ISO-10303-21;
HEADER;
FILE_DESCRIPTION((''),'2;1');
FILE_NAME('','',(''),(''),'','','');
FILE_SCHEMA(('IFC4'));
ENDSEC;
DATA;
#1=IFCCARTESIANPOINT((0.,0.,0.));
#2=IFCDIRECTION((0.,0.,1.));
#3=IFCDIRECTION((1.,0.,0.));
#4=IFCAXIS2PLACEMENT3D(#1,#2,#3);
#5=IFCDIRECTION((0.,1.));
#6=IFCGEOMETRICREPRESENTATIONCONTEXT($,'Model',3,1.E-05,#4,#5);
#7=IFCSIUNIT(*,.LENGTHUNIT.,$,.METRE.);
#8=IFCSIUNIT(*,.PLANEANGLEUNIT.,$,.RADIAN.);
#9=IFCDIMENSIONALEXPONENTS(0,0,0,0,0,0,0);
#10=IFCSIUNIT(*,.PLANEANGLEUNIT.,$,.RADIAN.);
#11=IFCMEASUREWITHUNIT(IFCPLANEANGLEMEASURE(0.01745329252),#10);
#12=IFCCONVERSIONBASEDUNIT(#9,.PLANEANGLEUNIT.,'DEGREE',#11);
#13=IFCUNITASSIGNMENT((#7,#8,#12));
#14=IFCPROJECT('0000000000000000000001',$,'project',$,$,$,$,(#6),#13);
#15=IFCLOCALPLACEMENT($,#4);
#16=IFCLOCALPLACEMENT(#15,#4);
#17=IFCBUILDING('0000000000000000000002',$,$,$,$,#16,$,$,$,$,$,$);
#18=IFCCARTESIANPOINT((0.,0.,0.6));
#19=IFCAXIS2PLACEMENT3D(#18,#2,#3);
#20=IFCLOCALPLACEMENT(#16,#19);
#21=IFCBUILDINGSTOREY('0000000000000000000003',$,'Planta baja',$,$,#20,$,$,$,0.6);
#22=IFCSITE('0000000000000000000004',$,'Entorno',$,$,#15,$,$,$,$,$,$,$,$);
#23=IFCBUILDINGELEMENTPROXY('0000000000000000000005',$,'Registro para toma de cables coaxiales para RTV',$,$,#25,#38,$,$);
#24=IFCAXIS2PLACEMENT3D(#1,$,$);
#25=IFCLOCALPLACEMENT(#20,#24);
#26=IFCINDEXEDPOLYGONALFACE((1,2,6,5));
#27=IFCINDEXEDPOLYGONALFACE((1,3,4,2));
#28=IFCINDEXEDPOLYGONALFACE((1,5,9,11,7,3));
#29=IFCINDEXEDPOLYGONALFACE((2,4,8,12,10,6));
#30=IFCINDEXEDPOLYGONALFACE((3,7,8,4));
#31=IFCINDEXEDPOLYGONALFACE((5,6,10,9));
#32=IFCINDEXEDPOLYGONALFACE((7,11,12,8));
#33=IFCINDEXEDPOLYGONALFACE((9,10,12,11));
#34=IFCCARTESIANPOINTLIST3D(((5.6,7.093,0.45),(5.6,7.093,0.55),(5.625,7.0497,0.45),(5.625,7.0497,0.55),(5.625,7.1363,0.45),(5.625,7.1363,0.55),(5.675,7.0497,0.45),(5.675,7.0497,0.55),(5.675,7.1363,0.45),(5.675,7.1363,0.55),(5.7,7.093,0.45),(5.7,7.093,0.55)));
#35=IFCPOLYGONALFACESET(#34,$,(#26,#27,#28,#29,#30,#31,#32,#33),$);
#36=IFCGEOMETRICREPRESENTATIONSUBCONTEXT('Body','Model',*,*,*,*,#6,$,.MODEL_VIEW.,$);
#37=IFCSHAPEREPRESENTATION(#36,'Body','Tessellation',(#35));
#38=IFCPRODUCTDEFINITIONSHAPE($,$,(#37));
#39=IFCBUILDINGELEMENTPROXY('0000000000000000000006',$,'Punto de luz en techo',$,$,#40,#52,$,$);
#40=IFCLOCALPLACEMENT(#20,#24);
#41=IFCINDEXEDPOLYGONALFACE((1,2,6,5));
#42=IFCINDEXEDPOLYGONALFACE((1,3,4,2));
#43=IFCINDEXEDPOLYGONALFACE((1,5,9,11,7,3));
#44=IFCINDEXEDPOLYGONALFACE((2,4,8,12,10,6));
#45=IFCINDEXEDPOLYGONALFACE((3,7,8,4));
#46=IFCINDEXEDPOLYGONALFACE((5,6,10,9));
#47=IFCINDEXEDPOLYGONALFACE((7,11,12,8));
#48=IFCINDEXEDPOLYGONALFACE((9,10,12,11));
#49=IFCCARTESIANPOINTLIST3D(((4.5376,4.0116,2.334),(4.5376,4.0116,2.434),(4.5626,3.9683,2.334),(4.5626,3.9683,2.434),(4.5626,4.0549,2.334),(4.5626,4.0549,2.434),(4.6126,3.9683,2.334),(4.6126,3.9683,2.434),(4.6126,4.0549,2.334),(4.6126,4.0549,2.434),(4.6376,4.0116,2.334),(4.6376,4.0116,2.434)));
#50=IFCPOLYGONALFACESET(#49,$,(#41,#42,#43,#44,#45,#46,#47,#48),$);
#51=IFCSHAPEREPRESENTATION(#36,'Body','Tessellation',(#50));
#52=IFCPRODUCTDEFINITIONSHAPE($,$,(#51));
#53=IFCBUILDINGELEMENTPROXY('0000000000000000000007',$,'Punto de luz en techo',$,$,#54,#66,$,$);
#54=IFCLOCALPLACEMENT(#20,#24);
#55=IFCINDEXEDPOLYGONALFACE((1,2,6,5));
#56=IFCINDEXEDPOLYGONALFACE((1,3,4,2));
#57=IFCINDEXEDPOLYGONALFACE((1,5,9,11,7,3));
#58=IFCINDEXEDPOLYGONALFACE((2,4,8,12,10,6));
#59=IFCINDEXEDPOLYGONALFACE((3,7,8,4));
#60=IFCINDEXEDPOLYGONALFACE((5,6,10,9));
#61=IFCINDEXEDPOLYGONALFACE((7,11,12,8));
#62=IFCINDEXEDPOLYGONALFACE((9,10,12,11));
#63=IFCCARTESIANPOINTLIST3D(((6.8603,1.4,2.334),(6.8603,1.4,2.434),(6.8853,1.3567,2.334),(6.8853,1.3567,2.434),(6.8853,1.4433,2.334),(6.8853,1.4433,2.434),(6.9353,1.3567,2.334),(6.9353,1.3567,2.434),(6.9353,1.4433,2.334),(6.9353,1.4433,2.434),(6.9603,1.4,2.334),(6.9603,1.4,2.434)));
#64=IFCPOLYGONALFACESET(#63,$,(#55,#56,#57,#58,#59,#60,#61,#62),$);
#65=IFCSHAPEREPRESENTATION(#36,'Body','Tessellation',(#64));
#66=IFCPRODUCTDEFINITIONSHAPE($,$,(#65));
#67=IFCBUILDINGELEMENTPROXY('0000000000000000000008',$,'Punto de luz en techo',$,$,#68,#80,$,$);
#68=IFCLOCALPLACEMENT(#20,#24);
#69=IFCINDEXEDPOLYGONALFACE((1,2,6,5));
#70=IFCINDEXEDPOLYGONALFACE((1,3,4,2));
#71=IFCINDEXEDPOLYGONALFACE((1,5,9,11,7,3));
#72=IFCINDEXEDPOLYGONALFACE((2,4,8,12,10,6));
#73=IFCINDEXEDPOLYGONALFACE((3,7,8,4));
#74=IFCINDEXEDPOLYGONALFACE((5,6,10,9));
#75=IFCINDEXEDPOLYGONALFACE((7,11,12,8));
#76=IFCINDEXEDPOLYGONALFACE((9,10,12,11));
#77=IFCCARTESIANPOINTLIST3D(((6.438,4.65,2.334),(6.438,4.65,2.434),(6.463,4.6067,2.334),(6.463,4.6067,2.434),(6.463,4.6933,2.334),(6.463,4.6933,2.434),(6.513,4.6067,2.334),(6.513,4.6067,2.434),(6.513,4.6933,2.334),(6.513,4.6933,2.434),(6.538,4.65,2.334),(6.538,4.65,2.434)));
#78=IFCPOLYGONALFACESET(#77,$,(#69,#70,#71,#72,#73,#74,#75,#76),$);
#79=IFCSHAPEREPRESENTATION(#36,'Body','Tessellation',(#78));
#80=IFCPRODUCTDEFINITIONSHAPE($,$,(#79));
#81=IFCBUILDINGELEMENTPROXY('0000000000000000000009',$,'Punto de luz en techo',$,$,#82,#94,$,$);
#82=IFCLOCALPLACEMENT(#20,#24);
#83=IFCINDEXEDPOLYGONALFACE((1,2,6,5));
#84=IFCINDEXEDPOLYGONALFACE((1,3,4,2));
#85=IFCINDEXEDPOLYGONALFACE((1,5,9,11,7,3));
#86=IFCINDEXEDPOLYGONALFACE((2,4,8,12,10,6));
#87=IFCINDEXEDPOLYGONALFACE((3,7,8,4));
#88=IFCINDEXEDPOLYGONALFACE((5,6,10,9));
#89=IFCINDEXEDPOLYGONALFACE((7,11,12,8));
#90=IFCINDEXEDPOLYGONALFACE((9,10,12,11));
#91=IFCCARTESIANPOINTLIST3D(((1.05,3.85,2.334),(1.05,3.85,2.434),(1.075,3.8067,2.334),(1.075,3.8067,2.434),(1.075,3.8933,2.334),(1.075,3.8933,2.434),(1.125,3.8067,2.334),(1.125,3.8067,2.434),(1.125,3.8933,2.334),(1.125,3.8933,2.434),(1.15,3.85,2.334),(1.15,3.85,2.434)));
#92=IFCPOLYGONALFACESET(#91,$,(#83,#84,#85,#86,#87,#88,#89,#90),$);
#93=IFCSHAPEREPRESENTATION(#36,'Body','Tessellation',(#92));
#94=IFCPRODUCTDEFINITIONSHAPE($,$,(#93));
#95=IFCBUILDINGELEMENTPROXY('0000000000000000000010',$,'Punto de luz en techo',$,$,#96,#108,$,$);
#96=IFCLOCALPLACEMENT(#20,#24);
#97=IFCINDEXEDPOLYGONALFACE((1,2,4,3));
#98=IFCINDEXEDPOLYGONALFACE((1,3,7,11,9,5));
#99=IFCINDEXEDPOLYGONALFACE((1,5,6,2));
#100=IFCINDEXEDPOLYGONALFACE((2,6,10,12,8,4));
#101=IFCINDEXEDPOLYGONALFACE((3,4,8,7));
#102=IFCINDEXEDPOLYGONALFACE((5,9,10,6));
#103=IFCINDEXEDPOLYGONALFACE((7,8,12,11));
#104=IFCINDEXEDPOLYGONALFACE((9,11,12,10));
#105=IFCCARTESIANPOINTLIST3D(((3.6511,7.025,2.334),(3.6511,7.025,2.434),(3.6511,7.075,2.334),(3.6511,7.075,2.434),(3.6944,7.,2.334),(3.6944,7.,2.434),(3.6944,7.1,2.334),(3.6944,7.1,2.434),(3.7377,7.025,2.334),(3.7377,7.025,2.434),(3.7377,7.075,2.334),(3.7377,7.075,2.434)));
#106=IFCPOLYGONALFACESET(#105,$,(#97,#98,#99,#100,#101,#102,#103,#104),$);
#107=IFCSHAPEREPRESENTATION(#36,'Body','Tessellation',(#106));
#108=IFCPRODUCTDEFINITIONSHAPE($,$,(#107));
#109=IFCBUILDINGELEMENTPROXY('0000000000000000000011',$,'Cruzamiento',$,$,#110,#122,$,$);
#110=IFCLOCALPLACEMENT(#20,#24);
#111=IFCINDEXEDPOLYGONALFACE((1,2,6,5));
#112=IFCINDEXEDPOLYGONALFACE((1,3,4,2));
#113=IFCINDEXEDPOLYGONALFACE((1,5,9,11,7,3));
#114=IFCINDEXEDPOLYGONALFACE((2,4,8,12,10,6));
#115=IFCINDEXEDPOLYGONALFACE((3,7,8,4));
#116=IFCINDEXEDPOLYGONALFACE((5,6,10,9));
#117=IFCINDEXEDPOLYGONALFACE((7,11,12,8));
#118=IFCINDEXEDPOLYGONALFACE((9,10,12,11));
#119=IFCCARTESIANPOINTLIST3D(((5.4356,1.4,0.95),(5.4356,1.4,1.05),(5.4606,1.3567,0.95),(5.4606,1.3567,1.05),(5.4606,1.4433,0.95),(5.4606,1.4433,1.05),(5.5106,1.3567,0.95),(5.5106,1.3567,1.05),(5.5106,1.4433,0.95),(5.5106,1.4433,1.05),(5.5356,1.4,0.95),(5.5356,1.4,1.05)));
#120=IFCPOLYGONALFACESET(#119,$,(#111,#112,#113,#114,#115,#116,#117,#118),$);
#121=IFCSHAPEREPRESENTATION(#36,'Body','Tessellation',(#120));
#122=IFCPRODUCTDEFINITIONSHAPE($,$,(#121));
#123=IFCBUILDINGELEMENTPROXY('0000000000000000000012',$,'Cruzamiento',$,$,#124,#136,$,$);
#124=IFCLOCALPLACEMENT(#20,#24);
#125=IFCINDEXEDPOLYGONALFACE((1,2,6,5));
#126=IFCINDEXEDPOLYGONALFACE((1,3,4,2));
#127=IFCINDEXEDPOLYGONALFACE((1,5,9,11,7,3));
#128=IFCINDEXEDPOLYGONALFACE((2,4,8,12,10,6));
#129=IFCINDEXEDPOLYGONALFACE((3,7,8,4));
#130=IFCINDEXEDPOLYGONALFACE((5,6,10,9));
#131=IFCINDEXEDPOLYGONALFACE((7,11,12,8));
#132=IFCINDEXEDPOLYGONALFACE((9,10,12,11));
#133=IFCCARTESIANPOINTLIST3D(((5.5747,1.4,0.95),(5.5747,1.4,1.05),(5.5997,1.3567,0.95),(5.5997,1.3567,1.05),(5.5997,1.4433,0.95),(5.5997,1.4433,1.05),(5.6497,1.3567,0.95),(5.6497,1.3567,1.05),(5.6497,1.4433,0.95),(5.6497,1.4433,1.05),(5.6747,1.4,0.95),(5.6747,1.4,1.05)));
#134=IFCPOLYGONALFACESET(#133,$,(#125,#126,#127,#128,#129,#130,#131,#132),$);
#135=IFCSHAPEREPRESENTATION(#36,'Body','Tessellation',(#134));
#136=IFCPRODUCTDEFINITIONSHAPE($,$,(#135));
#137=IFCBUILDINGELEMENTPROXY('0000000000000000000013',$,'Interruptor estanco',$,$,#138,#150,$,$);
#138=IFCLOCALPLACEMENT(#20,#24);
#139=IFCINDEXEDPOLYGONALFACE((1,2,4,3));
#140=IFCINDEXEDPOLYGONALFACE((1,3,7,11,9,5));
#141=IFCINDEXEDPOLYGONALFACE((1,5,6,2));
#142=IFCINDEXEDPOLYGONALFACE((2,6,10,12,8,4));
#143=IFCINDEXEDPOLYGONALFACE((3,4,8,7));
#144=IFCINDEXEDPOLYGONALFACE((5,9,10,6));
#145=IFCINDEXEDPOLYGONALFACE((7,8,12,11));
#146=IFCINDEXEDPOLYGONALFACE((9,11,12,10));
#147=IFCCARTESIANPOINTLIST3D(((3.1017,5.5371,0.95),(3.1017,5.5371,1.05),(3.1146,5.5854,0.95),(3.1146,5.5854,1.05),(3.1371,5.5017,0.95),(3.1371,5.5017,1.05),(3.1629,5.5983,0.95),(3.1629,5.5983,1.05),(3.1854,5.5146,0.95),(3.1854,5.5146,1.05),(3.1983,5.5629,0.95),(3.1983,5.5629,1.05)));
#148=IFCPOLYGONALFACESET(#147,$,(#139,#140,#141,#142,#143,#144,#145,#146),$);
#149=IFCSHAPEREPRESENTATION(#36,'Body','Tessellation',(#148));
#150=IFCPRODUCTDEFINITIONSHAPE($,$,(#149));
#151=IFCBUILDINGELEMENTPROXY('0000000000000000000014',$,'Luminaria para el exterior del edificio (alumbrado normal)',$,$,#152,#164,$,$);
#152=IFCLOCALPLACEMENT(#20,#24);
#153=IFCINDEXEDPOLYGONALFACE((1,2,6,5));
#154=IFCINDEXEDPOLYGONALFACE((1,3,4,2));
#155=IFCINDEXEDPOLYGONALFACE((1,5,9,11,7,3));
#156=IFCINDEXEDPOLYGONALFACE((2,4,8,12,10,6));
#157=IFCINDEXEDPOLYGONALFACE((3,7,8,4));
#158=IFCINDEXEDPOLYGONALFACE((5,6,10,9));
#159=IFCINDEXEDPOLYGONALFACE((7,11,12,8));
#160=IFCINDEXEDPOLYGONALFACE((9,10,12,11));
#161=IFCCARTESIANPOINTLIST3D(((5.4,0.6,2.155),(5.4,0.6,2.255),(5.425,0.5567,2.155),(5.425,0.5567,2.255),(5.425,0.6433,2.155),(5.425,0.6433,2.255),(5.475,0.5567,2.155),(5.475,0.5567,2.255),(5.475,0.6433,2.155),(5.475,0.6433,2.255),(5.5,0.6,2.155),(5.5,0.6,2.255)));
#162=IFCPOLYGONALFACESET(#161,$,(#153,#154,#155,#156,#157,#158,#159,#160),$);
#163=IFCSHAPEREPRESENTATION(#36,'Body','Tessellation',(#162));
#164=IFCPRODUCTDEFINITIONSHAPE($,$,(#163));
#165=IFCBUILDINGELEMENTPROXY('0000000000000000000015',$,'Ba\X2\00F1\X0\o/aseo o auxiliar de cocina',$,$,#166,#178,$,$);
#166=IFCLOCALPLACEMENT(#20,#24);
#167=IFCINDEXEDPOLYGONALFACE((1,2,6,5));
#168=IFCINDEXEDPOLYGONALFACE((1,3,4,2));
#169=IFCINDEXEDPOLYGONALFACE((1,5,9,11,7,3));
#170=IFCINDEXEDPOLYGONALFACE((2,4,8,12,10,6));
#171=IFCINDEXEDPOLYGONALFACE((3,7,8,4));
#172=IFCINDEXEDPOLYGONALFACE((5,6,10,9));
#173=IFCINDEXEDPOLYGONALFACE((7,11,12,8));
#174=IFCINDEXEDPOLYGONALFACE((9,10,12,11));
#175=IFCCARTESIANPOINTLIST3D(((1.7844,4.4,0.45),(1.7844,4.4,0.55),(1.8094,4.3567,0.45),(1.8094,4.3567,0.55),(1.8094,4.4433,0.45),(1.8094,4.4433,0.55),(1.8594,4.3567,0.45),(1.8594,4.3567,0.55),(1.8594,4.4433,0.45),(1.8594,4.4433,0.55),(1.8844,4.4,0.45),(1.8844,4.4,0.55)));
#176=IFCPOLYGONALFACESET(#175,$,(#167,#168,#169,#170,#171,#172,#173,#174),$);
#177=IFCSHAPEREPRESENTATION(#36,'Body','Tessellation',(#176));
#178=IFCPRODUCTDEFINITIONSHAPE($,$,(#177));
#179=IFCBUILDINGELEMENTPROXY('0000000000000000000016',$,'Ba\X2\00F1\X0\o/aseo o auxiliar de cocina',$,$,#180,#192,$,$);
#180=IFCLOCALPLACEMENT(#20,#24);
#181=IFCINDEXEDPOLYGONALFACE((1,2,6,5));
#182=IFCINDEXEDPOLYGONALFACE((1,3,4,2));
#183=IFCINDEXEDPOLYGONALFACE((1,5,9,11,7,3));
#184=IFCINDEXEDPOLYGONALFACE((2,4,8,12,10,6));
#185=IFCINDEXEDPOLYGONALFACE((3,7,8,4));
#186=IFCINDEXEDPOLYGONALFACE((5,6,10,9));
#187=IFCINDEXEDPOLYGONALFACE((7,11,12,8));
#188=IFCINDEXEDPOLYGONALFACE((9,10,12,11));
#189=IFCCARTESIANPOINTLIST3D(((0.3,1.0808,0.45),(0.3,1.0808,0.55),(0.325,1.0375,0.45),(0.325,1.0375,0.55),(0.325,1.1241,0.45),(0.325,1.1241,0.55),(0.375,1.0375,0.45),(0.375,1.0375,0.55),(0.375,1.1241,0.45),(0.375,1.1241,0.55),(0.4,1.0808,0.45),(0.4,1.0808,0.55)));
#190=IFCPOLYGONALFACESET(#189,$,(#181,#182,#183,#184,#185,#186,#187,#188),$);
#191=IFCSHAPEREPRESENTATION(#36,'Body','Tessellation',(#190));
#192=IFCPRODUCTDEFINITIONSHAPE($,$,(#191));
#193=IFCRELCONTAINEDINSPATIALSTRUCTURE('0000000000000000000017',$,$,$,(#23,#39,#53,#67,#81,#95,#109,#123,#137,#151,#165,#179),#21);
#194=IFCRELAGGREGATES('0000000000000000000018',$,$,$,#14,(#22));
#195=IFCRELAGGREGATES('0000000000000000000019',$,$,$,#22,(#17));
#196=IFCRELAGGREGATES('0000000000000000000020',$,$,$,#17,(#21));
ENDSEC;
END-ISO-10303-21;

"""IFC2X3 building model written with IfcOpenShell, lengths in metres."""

from ifc_helpers import new_model, entity, si_unit, converted_unit, direction, frame, origin_with_axes, place, context, subcontext, project, spatial, polyline, outline, extrude, source, transform, mapped, element, save


model = new_model("IFC2X3")

# Units and contexts
model_context = context("Model", 3, precision=1e-05, world=origin_with_axes(), true_north=direction((0.0, 1.0)))
body_context = subcontext(model_context, "Body", "Model", "MODEL_VIEW")
ifc_project = project(units=[si_unit("LENGTHUNIT", "METRE"), si_unit("PLANEANGLEUNIT", "RADIAN"), converted_unit("PLANEANGLEUNIT", "DEGREE", entity("IfcPlaneAngleMeasure", 0.01745329252), si_unit("PLANEANGLEUNIT", "RADIAN"), dimensions=[0, 0, 0, 0, 0, 0, 0])], contexts=[model_context])

# Site, building, storey
site_placement = place(None, origin_with_axes())
site = spatial("IfcSite", under=ifc_project, at=site_placement, Name="Entorno")
building_placement = place(site_placement, origin_with_axes())
building = spatial("IfcBuilding", under=site, at=building_placement)
storey_placement = place(building_placement, frame((0.0, 0.0, 0.6), z_axis=(0.0, 0.0, 1.0), x_axis=(1.0, 0.0, 0.0)))
storey = spatial("IfcBuildingStorey", under=building, at=storey_placement, Name="Planta baja", Elevation=0.6)

# Building element proxies
shared_shape_1 = source(origin_with_axes(), body_context, "Body", "SolidModel", [
    extrude(outline(polyline([(0.05, 0.0), (0.025, 0.0433), (-0.025, 0.0433), (-0.05, 0.0), (-0.025, -0.0433), (0.025, -0.0433), (0.05, 0.0)])), frame((0.0, 0.0, -0.05), z_axis=(0.0, 0.0, 1.0), x_axis=(1.0, 0.0, 0.0)), (0.0, 0.0, 1.0), 0.1),
])
proxy_1_placement = place(storey_placement, frame((0.0, 0.0, -0.6), z_axis=(0.0, 0.0, 1.0), x_axis=(1.0, 0.0, 0.0)))
element("IfcBuildingElementProxy", 1, at=proxy_1_placement, inside=storey, Name="Registro para toma de cables coaxiales para RTV", context=body_context, shape_type="Brep", body=[
    mapped(shared_shape_1, transform((5.65, 7.093, 1.1), x_axis=(1.0, 0.0, 0.0), y_axis=(0.0, 1.0, 0.0), z_axis=(0.0, 0.0, 1.0))),
])
shared_shape_2 = source(origin_with_axes(), body_context, "Body", "SolidModel", [
    extrude(outline(polyline([(0.05, 0.0), (0.025, 0.0433), (-0.025, 0.0433), (-0.05, 0.0), (-0.025, -0.0433), (0.025, -0.0433), (0.05, 0.0)])), frame((0.0, 0.0, -0.05), z_axis=(0.0, 0.0, 1.0), x_axis=(1.0, 0.0, 0.0)), (0.0, 0.0, 1.0), 0.1),
])
proxy_2_placement = place(storey_placement, frame((0.0, 0.0, -0.6), z_axis=(0.0, 0.0, 1.0), x_axis=(1.0, 0.0, 0.0)))
element("IfcBuildingElementProxy", 2, at=proxy_2_placement, inside=storey, Name="Punto de luz en techo", context=body_context, shape_type="Brep", body=[
    mapped(shared_shape_2, transform((4.5876, 4.0116, 2.984), x_axis=(1.0, 0.0, 0.0), y_axis=(0.0, 1.0, 0.0), z_axis=(0.0, 0.0, 1.0))),
])
proxy_3_placement = place(storey_placement, frame((0.0, 0.0, -0.6), z_axis=(0.0, 0.0, 1.0), x_axis=(1.0, 0.0, 0.0)))
element("IfcBuildingElementProxy", 3, at=proxy_3_placement, inside=storey, Name="Punto de luz en techo", context=body_context, shape_type="Brep", body=[
    mapped(shared_shape_2, transform((6.9103, 1.4, 2.984), x_axis=(1.0, 0.0, 0.0), y_axis=(0.0, 1.0, 0.0), z_axis=(0.0, 0.0, 1.0))),
])
proxy_4_placement = place(storey_placement, frame((0.0, 0.0, -0.6), z_axis=(0.0, 0.0, 1.0), x_axis=(1.0, 0.0, 0.0)))
element("IfcBuildingElementProxy", 4, at=proxy_4_placement, inside=storey, Name="Punto de luz en techo", context=body_context, shape_type="Brep", body=[
    mapped(shared_shape_2, transform((6.488, 4.65, 2.984), x_axis=(1.0, 0.0, 0.0), y_axis=(0.0, 1.0, 0.0), z_axis=(0.0, 0.0, 1.0))),
])
proxy_5_placement = place(storey_placement, frame((0.0, 0.0, -0.6), z_axis=(0.0, 0.0, 1.0), x_axis=(1.0, 0.0, 0.0)))
element("IfcBuildingElementProxy", 5, at=proxy_5_placement, inside=storey, Name="Punto de luz en techo", context=body_context, shape_type="Brep", body=[
    mapped(shared_shape_2, transform((1.1, 3.85, 2.984), x_axis=(1.0, 0.0, 0.0), y_axis=(0.0, 1.0, 0.0), z_axis=(0.0, 0.0, 1.0))),
])
proxy_6_placement = place(storey_placement, frame((0.0, 0.0, -0.6), z_axis=(0.0, 0.0, 1.0), x_axis=(1.0, 0.0, 0.0)))
element("IfcBuildingElementProxy", 6, at=proxy_6_placement, inside=storey, Name="Punto de luz en techo", context=body_context, shape_type="Brep", body=[
    mapped(shared_shape_2, transform((3.6944, 7.05, 2.984), x_axis=(0.0, 1.0, 0.0), y_axis=(-1.0, 0.0, 0.0), z_axis=(0.0, 0.0, 1.0))),
])
shared_shape_3 = source(origin_with_axes(), body_context, "Body", "SolidModel", [
    extrude(outline(polyline([(0.05, 0.0), (0.025, 0.0433), (-0.025, 0.0433), (-0.05, 0.0), (-0.025, -0.0433), (0.025, -0.0433), (0.05, 0.0)])), frame((0.0, 0.0, -0.05), z_axis=(0.0, 0.0, 1.0), x_axis=(1.0, 0.0, 0.0)), (0.0, 0.0, 1.0), 0.1),
])
proxy_7_placement = place(storey_placement, frame((0.0, 0.0, -0.6), z_axis=(0.0, 0.0, 1.0), x_axis=(1.0, 0.0, 0.0)))
element("IfcBuildingElementProxy", 7, at=proxy_7_placement, inside=storey, Name="Cruzamiento", context=body_context, shape_type="Brep", body=[
    mapped(shared_shape_3, transform((5.4856, 1.4, 1.6), x_axis=(1.0, 0.0, 0.0), y_axis=(0.0, 1.0, 0.0), z_axis=(0.0, 0.0, 1.0))),
])
proxy_8_placement = place(storey_placement, frame((0.0, 0.0, -0.6), z_axis=(0.0, 0.0, 1.0), x_axis=(1.0, 0.0, 0.0)))
element("IfcBuildingElementProxy", 8, at=proxy_8_placement, inside=storey, Name="Cruzamiento", context=body_context, shape_type="Brep", body=[
    mapped(shared_shape_3, transform((5.6247, 1.4, 1.6), x_axis=(1.0, 0.0, 0.0), y_axis=(0.0, 1.0, 0.0), z_axis=(0.0, 0.0, 1.0))),
])
shared_shape_4 = source(origin_with_axes(), body_context, "Body", "SolidModel", [
    extrude(outline(polyline([(0.05, 0.0), (0.025, 0.0433), (-0.025, 0.0433), (-0.05, 0.0), (-0.025, -0.0433), (0.025, -0.0433), (0.05, 0.0)])), frame((0.0, 0.0, -0.05), z_axis=(0.0, 0.0, 1.0), x_axis=(1.0, 0.0, 0.0)), (0.0, 0.0, 1.0), 0.1),
])
proxy_9_placement = place(storey_placement, frame((0.0, 0.0, -0.6), z_axis=(0.0, 0.0, 1.0), x_axis=(1.0, 0.0, 0.0)))
element("IfcBuildingElementProxy", 9, at=proxy_9_placement, inside=storey, Name="Interruptor estanco", context=body_context, shape_type="Brep", body=[
    mapped(shared_shape_4, transform((3.15, 5.55, 1.6), x_axis=(0.707107, -0.707107, 0.0), y_axis=(0.707107, 0.707107, 0.0), z_axis=(0.0, 0.0, 1.0))),
])
shared_shape_5 = source(origin_with_axes(), body_context, "Body", "SolidModel", [
    extrude(outline(polyline([(0.05, 0.0), (0.025, 0.0433), (-0.025, 0.0433), (-0.05, 0.0), (-0.025, -0.0433), (0.025, -0.0433), (0.05, 0.0)])), frame((0.0, 0.0, -0.05), z_axis=(0.0, 0.0, 1.0), x_axis=(1.0, 0.0, 0.0)), (0.0, 0.0, 1.0), 0.1),
])
proxy_10_placement = place(storey_placement, frame((0.0, 0.0, -0.6), z_axis=(0.0, 0.0, 1.0), x_axis=(1.0, 0.0, 0.0)))
element("IfcBuildingElementProxy", 10, at=proxy_10_placement, inside=storey, Name="Luminaria para el exterior del edificio (alumbrado normal)", context=body_context, shape_type="Brep", body=[
    mapped(shared_shape_5, transform((5.45, 0.6, 2.805), x_axis=(-1.0, 0.0, 0.0), y_axis=(0.0, -1.0, 0.0), z_axis=(0.0, 0.0, 1.0))),
])
shared_shape_6 = source(origin_with_axes(), body_context, "Body", "SolidModel", [
    extrude(outline(polyline([(0.05, 0.0), (0.025, 0.0433), (-0.025, 0.0433), (-0.05, 0.0), (-0.025, -0.0433), (0.025, -0.0433), (0.05, 0.0)])), frame((0.0, 0.0, -0.05), z_axis=(0.0, 0.0, 1.0), x_axis=(1.0, 0.0, 0.0)), (0.0, 0.0, 1.0), 0.1),
])
proxy_11_placement = place(storey_placement, frame((0.0, 0.0, -0.6), z_axis=(0.0, 0.0, 1.0), x_axis=(1.0, 0.0, 0.0)))
element("IfcBuildingElementProxy", 11, at=proxy_11_placement, inside=storey, Name="Baño/aseo o auxiliar de cocina", context=body_context, shape_type="Brep", body=[
    mapped(shared_shape_6, transform((1.8344, 4.4, 1.1), x_axis=(-1.0, 0.0, 0.0), y_axis=(0.0, -1.0, 0.0), z_axis=(0.0, 0.0, 1.0))),
])
proxy_12_placement = place(storey_placement, frame((0.0, 0.0, -0.6), z_axis=(0.0, 0.0, 1.0), x_axis=(1.0, 0.0, 0.0)))
element("IfcBuildingElementProxy", 12, at=proxy_12_placement, inside=storey, Name="Baño/aseo o auxiliar de cocina", context=body_context, shape_type="Brep", body=[
    mapped(shared_shape_6, transform((0.35, 1.0808, 1.1), x_axis=(1.0, 0.0, 0.0), y_axis=(0.0, 1.0, 0.0), z_axis=(0.0, 0.0, 1.0))),
])

save(model, "model.ifc")
